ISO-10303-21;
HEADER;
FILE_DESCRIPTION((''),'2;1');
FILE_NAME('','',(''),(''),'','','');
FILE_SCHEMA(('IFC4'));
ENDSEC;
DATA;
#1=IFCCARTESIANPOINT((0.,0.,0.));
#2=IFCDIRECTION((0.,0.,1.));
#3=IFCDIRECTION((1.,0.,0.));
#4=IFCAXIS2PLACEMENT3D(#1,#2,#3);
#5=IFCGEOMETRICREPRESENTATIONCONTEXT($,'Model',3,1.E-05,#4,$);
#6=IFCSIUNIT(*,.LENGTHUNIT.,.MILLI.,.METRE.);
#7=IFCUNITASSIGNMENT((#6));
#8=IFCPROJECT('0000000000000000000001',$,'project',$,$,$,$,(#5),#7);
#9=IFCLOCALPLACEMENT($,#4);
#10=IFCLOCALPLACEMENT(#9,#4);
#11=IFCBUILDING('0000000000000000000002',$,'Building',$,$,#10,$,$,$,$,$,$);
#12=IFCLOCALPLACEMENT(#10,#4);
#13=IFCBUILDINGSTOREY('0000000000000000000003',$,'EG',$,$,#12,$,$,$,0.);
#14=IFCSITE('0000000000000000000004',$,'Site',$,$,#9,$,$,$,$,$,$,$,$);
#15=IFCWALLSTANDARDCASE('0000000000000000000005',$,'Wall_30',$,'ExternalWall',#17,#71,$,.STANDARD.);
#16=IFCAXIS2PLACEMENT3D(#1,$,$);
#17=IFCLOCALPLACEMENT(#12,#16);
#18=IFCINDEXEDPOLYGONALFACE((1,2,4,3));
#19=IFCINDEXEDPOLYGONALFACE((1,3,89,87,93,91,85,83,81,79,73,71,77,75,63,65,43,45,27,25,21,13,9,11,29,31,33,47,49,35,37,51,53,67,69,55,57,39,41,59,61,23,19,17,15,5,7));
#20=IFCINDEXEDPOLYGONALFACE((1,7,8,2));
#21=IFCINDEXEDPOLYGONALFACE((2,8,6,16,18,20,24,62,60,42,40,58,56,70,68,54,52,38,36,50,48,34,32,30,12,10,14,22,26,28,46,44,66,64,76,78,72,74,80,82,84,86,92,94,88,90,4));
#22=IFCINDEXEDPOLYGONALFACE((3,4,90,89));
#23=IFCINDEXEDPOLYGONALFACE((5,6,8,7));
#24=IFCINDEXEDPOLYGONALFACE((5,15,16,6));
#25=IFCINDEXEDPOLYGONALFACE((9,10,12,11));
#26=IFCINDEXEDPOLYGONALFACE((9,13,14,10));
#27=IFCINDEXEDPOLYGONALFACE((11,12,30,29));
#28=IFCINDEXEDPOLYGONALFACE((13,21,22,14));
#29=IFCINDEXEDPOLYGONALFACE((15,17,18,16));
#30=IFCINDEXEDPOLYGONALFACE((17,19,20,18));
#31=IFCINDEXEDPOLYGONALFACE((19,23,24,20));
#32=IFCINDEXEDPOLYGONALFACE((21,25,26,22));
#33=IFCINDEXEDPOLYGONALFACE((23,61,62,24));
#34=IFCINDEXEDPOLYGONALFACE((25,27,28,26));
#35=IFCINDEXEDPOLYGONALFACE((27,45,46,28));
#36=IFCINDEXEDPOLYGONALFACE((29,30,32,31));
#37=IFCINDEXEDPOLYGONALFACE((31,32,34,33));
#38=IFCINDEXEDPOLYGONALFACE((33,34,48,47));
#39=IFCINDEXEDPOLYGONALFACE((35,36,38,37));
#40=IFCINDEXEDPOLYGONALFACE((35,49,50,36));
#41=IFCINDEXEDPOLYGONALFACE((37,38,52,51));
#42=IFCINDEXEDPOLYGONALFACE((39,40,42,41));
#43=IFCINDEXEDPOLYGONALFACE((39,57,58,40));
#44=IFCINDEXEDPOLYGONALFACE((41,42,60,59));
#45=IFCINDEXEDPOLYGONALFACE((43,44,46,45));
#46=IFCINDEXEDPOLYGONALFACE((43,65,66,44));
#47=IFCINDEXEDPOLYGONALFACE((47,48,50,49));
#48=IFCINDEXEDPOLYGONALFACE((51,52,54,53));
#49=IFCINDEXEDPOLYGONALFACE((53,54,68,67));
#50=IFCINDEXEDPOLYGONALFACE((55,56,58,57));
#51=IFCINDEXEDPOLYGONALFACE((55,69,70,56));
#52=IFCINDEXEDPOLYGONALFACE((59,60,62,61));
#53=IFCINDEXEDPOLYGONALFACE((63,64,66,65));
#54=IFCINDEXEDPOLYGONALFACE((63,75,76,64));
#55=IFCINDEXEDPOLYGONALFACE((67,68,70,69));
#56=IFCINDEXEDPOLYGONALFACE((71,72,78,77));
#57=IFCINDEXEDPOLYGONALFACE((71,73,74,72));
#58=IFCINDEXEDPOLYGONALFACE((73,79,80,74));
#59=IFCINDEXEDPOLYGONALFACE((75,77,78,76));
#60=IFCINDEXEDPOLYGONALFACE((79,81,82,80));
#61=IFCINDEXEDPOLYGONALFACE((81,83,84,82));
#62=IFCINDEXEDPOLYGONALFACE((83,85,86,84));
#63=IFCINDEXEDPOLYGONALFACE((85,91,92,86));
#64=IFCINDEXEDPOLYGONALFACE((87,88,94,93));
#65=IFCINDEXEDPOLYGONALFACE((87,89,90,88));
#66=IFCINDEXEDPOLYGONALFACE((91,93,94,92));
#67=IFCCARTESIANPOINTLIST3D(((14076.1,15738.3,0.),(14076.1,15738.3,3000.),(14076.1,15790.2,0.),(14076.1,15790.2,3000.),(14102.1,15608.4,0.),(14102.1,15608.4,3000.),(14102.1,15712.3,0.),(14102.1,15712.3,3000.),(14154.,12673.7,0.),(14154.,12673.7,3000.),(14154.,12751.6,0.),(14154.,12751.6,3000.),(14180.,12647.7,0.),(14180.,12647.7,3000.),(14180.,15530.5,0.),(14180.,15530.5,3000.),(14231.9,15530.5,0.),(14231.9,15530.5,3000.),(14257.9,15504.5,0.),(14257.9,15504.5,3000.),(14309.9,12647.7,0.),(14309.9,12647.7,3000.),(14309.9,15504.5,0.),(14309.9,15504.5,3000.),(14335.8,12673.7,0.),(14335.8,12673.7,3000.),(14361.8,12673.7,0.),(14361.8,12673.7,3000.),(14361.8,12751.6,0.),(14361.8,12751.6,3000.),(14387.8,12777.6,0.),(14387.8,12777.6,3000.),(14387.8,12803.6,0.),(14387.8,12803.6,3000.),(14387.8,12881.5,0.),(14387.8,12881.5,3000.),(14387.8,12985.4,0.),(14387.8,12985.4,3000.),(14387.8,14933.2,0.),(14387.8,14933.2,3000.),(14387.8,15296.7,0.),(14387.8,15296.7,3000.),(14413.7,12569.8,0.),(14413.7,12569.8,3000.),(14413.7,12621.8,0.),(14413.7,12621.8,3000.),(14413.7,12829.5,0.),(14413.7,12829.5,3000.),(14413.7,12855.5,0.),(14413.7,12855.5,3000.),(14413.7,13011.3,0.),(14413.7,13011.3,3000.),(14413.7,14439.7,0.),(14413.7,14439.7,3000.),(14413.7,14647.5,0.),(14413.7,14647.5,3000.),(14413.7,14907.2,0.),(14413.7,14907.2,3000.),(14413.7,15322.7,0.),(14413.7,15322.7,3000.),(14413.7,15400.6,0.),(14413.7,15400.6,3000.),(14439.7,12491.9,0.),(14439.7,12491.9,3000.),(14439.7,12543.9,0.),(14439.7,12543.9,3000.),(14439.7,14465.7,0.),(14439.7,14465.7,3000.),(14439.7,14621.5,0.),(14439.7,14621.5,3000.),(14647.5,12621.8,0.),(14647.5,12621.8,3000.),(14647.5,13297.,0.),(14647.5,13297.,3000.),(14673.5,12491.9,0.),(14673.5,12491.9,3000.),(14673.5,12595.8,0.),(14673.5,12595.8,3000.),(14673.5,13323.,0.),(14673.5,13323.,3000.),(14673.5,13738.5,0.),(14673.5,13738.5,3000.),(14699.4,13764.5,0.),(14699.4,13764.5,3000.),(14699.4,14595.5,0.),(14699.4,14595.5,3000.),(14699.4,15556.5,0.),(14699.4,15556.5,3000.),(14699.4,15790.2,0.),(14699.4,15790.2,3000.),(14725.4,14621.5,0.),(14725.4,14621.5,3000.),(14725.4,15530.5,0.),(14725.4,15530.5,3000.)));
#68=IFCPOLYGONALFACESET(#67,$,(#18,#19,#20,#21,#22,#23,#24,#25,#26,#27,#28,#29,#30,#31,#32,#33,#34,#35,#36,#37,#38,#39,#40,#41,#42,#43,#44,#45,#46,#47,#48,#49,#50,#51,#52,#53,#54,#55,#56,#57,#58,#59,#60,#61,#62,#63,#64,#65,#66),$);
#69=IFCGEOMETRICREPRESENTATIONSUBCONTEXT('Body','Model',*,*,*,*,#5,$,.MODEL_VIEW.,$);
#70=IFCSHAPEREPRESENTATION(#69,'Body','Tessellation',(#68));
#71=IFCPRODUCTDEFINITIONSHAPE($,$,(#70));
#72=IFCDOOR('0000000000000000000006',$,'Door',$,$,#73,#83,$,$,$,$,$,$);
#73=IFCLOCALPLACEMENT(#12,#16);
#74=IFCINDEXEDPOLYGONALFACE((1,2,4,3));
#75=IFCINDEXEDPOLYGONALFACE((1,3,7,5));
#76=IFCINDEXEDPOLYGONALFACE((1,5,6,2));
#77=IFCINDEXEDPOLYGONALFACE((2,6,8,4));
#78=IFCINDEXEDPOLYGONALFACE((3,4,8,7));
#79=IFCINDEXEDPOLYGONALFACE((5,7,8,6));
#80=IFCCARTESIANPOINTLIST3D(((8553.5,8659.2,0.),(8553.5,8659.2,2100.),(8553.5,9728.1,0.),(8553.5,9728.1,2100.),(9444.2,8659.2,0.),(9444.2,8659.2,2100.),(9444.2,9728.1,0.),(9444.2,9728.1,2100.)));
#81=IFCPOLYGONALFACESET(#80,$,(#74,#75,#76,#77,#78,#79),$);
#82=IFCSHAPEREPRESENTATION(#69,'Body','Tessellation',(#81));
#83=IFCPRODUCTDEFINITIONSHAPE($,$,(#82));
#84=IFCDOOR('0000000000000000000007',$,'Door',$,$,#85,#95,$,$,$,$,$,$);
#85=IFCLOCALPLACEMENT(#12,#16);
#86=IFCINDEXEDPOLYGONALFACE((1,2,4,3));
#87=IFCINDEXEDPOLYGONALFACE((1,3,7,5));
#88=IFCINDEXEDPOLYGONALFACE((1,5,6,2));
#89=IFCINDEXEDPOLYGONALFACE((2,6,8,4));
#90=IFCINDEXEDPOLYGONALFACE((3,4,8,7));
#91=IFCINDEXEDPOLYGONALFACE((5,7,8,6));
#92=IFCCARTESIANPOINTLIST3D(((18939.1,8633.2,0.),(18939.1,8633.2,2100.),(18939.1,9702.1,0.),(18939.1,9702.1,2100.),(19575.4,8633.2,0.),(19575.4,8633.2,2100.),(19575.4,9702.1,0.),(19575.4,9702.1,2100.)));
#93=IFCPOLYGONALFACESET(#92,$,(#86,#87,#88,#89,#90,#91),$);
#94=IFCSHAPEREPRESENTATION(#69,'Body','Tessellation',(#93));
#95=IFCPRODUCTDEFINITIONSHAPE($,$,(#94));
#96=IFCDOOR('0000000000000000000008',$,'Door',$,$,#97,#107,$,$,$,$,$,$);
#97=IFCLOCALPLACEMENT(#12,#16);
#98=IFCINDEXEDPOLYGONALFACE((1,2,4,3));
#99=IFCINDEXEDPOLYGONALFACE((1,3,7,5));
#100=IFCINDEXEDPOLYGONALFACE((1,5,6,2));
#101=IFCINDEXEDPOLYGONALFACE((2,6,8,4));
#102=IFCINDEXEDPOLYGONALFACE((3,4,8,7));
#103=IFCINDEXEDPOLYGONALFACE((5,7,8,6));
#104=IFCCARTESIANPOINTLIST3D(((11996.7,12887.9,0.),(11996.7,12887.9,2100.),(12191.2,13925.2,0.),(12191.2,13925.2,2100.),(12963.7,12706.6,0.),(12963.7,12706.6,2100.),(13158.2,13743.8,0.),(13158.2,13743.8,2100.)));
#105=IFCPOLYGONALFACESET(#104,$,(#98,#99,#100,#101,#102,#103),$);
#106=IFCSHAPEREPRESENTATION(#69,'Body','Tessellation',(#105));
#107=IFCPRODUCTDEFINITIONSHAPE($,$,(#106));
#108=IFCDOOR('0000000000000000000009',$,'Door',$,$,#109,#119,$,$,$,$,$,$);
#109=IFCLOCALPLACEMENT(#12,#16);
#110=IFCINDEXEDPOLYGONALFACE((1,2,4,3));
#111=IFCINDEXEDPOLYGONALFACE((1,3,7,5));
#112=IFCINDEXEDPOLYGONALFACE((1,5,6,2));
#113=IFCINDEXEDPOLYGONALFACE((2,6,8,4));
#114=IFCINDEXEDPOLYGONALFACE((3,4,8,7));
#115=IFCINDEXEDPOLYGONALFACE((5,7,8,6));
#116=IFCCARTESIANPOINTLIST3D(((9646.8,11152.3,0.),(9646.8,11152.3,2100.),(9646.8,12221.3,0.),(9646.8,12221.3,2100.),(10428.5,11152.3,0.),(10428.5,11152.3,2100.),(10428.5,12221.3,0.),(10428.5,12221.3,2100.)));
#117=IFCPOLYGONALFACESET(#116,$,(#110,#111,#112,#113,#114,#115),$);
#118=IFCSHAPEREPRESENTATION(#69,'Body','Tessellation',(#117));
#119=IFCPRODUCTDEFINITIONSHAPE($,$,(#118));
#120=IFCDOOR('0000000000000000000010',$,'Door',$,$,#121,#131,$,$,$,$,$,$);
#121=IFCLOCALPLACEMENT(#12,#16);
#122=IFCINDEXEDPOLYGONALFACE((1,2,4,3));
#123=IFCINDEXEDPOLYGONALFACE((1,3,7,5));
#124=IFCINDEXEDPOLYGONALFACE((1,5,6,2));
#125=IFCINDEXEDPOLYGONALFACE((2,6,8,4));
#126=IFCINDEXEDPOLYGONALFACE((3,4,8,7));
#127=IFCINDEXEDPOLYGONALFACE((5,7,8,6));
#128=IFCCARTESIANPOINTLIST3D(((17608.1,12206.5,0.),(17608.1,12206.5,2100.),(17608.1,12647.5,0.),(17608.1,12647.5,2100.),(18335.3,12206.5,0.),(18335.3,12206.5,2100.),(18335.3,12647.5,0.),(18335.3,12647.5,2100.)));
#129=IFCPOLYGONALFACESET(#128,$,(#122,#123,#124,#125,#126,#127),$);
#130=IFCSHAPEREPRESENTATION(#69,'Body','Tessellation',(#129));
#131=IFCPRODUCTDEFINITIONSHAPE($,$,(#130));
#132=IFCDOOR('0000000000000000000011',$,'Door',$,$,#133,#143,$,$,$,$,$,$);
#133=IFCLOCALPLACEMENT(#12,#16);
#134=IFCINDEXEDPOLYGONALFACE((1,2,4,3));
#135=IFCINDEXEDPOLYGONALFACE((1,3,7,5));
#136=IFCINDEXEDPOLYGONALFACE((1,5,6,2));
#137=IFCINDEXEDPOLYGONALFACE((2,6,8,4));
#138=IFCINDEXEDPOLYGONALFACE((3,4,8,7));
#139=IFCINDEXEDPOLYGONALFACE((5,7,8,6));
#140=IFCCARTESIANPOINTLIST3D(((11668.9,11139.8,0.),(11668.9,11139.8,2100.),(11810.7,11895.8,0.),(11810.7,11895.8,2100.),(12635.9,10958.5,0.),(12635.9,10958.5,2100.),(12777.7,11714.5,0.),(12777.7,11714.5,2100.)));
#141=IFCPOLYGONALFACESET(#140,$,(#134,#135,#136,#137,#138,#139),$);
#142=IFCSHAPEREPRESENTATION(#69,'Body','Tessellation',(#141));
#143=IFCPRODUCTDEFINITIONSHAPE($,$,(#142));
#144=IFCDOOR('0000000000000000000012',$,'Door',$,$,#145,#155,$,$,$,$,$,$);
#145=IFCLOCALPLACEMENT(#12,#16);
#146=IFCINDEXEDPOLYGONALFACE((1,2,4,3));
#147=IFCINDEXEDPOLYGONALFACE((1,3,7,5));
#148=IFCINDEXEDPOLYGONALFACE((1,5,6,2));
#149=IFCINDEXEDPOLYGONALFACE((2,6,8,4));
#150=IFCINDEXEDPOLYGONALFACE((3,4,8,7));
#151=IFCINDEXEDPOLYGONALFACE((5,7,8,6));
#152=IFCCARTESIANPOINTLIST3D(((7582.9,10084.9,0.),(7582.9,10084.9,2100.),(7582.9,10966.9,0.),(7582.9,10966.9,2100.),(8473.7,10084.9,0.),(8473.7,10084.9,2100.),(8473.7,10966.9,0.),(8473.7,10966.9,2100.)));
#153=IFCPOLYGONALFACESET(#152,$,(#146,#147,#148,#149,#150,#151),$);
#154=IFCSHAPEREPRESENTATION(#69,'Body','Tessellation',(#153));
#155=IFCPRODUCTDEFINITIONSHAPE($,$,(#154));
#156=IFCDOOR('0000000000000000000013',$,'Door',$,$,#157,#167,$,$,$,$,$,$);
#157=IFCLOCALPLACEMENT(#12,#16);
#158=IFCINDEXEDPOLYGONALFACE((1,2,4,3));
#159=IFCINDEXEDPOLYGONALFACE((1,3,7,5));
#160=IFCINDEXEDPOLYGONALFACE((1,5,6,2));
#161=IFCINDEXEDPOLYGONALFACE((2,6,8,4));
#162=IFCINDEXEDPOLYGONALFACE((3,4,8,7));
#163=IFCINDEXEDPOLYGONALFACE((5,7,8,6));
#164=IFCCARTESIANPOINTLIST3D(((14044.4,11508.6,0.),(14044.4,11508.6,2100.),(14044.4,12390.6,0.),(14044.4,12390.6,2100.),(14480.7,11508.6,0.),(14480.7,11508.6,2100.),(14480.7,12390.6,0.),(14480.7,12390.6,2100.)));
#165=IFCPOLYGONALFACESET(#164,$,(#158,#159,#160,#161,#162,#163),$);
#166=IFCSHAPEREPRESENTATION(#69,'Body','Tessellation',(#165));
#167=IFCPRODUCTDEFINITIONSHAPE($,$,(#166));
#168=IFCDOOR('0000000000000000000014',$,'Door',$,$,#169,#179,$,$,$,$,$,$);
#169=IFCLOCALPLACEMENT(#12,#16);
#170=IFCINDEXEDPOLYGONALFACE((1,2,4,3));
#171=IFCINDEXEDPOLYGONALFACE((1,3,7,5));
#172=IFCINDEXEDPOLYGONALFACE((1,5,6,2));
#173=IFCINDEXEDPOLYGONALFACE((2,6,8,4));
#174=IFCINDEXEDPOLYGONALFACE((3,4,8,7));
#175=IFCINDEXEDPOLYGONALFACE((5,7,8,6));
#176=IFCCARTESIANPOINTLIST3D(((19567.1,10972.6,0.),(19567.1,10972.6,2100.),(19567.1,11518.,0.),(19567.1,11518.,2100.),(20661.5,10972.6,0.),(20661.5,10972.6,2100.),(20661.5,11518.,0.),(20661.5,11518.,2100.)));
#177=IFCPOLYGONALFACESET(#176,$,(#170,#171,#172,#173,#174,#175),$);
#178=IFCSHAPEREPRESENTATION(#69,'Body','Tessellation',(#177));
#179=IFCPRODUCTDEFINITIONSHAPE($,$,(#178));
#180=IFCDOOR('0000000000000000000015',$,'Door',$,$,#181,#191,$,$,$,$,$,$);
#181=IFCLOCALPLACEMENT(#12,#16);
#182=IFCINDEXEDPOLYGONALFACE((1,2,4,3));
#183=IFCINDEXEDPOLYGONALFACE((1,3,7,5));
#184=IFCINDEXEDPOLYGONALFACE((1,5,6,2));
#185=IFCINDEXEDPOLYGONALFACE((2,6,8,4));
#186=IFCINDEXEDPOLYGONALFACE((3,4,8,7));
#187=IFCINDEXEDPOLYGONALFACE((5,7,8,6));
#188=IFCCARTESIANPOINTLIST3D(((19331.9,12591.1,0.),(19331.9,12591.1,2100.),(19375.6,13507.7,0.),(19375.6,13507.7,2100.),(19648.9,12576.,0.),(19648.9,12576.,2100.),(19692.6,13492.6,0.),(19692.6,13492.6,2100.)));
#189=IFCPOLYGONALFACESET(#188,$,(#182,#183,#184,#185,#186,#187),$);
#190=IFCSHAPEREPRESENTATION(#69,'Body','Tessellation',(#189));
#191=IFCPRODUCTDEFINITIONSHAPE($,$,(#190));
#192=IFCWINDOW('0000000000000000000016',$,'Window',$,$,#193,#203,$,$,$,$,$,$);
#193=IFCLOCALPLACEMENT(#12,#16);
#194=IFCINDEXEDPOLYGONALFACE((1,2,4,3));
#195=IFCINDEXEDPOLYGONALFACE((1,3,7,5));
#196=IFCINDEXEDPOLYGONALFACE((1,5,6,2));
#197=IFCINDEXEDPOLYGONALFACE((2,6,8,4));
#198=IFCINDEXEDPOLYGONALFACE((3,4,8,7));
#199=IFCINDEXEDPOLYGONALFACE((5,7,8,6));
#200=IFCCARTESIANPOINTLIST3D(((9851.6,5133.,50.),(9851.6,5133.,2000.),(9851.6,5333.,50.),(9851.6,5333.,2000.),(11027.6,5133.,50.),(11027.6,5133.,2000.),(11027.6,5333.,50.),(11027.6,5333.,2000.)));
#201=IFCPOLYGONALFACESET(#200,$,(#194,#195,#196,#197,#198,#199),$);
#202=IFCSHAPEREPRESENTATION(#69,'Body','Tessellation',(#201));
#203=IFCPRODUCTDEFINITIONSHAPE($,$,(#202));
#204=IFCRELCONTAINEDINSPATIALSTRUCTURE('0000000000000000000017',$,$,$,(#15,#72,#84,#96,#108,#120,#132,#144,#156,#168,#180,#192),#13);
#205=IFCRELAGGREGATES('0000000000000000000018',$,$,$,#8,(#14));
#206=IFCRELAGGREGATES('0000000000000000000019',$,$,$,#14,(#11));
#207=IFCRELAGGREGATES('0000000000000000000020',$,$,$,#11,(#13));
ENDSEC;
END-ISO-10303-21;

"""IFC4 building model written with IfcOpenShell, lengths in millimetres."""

from ifc_helpers import new_model, si_unit, frame, origin_with_axes, place, context, subcontext, project, spatial, polyline, rectangle, outline, extrude, element, save


model = new_model("IFC4")

# Units and contexts
model_context = context("Model", 3, precision=1e-05, world=origin_with_axes())
body_context = subcontext(model_context, "Body", "Model", "MODEL_VIEW")
ifc_project = project(units=[si_unit("LENGTHUNIT", "METRE", prefix="MILLI")], contexts=[model_context])

# Site, building, storey
site_placement = place(None, origin_with_axes())
site = spatial("IfcSite", under=ifc_project, at=site_placement, Name="Site")
building_placement = place(site_placement, origin_with_axes())
building = spatial("IfcBuilding", under=site, at=building_placement, Name="Building")
storey_placement = place(building_placement, origin_with_axes())
storey = spatial("IfcBuildingStorey", under=building, at=storey_placement, Name="EG", Elevation=0.0)

# Wall
wall_placement = place(storey_placement, origin_with_axes())
element("IfcWallStandardCase", 1, at=wall_placement, inside=storey, Name="Wall_30", ObjectType="ExternalWall", PredefinedType="STANDARD", context=body_context, shape_type="SweptSolid", body=[
    extrude(outline(polyline([(14439.7, 12491.9, 0.0), (14439.7, 12543.9, 0.0), (14413.7, 12569.8, 0.0), (14413.7, 12621.8, 0.0), (14361.8, 12673.7, 0.0), (14335.8, 12673.7, 0.0), (14309.9, 12647.7, 0.0), (14180.0, 12647.7, 0.0), (14154.0, 12673.7, 0.0), (14154.0, 12751.6, 0.0), (14361.8, 12751.6, 0.0), (14387.8, 12777.6, 0.0), (14387.8, 12803.6, 0.0), (14413.7, 12829.5, 0.0), (14413.7, 12855.5, 0.0), (14387.8, 12881.5, 0.0), (14387.8, 12985.4, 0.0), (14413.7, 13011.3, 0.0), (14413.7, 14439.7, 0.0), (14439.7, 14465.7, 0.0), (14439.7, 14621.5, 0.0), (14413.7, 14647.5, 0.0), (14413.7, 14907.2, 0.0), (14387.8, 14933.2, 0.0), (14387.8, 15296.7, 0.0), (14413.7, 15322.7, 0.0), (14413.7, 15400.6, 0.0), (14309.9, 15504.5, 0.0), (14257.9, 15504.5, 0.0), (14231.9, 15530.5, 0.0), (14180.0, 15530.5, 0.0), (14102.1, 15608.4, 0.0), (14102.1, 15712.3, 0.0), (14076.1, 15738.3, 0.0), (14076.1, 15790.2, 0.0), (14699.4, 15790.2, 0.0), (14699.4, 15556.5, 0.0), (14725.4, 15530.5, 0.0), (14725.4, 14621.5, 0.0), (14699.4, 14595.5, 0.0), (14699.4, 13764.5, 0.0), (14673.5, 13738.5, 0.0), (14673.5, 13323.0, 0.0), (14647.5, 13297.0, 0.0), (14647.5, 12621.8, 0.0), (14673.5, 12595.8, 0.0), (14673.5, 12491.9, 0.0), (14439.7, 12491.9, 0.0)])), origin_with_axes(), (0.0, 0.0, 1.0), 3000.0),
])

# Doors
door_1_placement = place(storey_placement, origin_with_axes())
element("IfcDoor", 2, at=door_1_placement, inside=storey, Name="Door", context=body_context, shape_type="SweptSolid", body=[
    extrude(rectangle(XDim=1069.0, YDim=890.8), frame((8998.9, 9193.6, 0.0), z_axis=(0.0, 0.0, 1.0), x_axis=(0.0, 1.0, 0.0)), (0.0, 0.0, 1.0), 2100.0),
])
door_2_placement = place(storey_placement, origin_with_axes())
element("IfcDoor", 3, at=door_2_placement, inside=storey, Name="Door", context=body_context, shape_type="SweptSolid", body=[
    extrude(rectangle(XDim=1069.0, YDim=636.3), frame((19257.3, 9167.7, 0.0), z_axis=(0.0, 0.0, 1.0), x_axis=(0.0, -1.0, 0.0)), (0.0, 0.0, 1.0), 2100.0),
])
door_3_placement = place(storey_placement, origin_with_axes())
element("IfcDoor", 4, at=door_3_placement, inside=storey, Name="Door", context=body_context, shape_type="SweptSolid", body=[
    extrude(rectangle(XDim=1055.3, YDim=983.9), frame((12577.4, 13315.9, 0.0), z_axis=(0.0, 0.0, 1.0), x_axis=(0.184288, 0.982872, 0.0)), (0.0, 0.0, 1.0), 2100.0),
])
door_4_placement = place(storey_placement, origin_with_axes())
element("IfcDoor", 5, at=door_4_placement, inside=storey, Name="Door", context=body_context, shape_type="SweptSolid", body=[
    extrude(rectangle(XDim=1069.0, YDim=781.7), frame((10037.7, 11686.8, 0.0), z_axis=(0.0, 0.0, 1.0), x_axis=(0.0, -1.0, 0.0)), (0.0, 0.0, 1.0), 2100.0),
])
door_5_placement = place(storey_placement, origin_with_axes())
element("IfcDoor", 6, at=door_5_placement, inside=storey, Name="Door", context=body_context, shape_type="SweptSolid", body=[
    extrude(rectangle(XDim=441.0, YDim=727.2), frame((17971.7, 12427.0, 0.0), z_axis=(0.0, 0.0, 1.0), x_axis=(0.0, 1.0, 0.0)), (0.0, 0.0, 1.0), 2100.0),
])
door_6_placement = place(storey_placement, origin_with_axes())
element("IfcDoor", 7, at=door_6_placement, inside=storey, Name="Door", context=body_context, shape_type="SweptSolid", body=[
    extrude(rectangle(XDim=769.2, YDim=983.9), frame((12223.3, 11427.2, 0.0), z_axis=(0.0, 0.0, 1.0), x_axis=(0.184288, 0.982872, 0.0)), (0.0, 0.0, 1.0), 2100.0),
])
door_7_placement = place(storey_placement, origin_with_axes())
element("IfcDoor", 8, at=door_7_placement, inside=storey, Name="Door", context=body_context, shape_type="SweptSolid", body=[
    extrude(rectangle(XDim=882.0, YDim=890.8), frame((8028.3, 10525.9, 0.0), z_axis=(0.0, 0.0, 1.0), x_axis=(0.0, 1.0, 0.0)), (0.0, 0.0, 1.0), 2100.0),
])
door_8_placement = place(storey_placement, origin_with_axes())
element("IfcDoor", 9, at=door_8_placement, inside=storey, Name="Door", context=body_context, shape_type="SweptSolid", body=[
    extrude(rectangle(XDim=882.0, YDim=436.3), frame((14262.5, 11949.6, 0.0), z_axis=(0.0, 0.0, 1.0), x_axis=(0.0, -1.0, 0.0)), (0.0, 0.0, 1.0), 2100.0),
])
door_9_placement = place(storey_placement, origin_with_axes())
element("IfcDoor", 10, at=door_9_placement, inside=storey, Name="Door", context=body_context, shape_type="SweptSolid", body=[
    extrude(rectangle(XDim=1094.4, YDim=545.4), frame((20114.3, 11245.3, 0.0), z_axis=(0.0, 0.0, 1.0), x_axis=(1.0, 0.0, 0.0)), (0.0, 0.0, 1.0), 2100.0),
])
door_10_placement = place(storey_placement, origin_with_axes())
element("IfcDoor", 11, at=door_10_placement, inside=storey, Name="Door", context=body_context, shape_type="SweptSolid", body=[
    extrude(rectangle(XDim=917.6, YDim=317.3), frame((19512.3, 13041.9, 0.0), z_axis=(0.0, 0.0, 1.0), x_axis=(-0.047565, -0.998868, 0.0)), (0.0, 0.0, 1.0), 2100.0),
])

# Window
window_1_placement = place(storey_placement, origin_with_axes())
element("IfcWindow", 12, at=window_1_placement, inside=storey, Name="Window", context=body_context, shape_type="SweptSolid", body=[
    extrude(rectangle(XDim=1176.0, YDim=200.0), frame((10439.6, 5233.0, 50.0), z_axis=(0.0, 0.0, 1.0), x_axis=(1.0, 0.0, 0.0)), (0.0, 0.0, 1.0), 1950.0),
])

save(model, "model.ifc")
